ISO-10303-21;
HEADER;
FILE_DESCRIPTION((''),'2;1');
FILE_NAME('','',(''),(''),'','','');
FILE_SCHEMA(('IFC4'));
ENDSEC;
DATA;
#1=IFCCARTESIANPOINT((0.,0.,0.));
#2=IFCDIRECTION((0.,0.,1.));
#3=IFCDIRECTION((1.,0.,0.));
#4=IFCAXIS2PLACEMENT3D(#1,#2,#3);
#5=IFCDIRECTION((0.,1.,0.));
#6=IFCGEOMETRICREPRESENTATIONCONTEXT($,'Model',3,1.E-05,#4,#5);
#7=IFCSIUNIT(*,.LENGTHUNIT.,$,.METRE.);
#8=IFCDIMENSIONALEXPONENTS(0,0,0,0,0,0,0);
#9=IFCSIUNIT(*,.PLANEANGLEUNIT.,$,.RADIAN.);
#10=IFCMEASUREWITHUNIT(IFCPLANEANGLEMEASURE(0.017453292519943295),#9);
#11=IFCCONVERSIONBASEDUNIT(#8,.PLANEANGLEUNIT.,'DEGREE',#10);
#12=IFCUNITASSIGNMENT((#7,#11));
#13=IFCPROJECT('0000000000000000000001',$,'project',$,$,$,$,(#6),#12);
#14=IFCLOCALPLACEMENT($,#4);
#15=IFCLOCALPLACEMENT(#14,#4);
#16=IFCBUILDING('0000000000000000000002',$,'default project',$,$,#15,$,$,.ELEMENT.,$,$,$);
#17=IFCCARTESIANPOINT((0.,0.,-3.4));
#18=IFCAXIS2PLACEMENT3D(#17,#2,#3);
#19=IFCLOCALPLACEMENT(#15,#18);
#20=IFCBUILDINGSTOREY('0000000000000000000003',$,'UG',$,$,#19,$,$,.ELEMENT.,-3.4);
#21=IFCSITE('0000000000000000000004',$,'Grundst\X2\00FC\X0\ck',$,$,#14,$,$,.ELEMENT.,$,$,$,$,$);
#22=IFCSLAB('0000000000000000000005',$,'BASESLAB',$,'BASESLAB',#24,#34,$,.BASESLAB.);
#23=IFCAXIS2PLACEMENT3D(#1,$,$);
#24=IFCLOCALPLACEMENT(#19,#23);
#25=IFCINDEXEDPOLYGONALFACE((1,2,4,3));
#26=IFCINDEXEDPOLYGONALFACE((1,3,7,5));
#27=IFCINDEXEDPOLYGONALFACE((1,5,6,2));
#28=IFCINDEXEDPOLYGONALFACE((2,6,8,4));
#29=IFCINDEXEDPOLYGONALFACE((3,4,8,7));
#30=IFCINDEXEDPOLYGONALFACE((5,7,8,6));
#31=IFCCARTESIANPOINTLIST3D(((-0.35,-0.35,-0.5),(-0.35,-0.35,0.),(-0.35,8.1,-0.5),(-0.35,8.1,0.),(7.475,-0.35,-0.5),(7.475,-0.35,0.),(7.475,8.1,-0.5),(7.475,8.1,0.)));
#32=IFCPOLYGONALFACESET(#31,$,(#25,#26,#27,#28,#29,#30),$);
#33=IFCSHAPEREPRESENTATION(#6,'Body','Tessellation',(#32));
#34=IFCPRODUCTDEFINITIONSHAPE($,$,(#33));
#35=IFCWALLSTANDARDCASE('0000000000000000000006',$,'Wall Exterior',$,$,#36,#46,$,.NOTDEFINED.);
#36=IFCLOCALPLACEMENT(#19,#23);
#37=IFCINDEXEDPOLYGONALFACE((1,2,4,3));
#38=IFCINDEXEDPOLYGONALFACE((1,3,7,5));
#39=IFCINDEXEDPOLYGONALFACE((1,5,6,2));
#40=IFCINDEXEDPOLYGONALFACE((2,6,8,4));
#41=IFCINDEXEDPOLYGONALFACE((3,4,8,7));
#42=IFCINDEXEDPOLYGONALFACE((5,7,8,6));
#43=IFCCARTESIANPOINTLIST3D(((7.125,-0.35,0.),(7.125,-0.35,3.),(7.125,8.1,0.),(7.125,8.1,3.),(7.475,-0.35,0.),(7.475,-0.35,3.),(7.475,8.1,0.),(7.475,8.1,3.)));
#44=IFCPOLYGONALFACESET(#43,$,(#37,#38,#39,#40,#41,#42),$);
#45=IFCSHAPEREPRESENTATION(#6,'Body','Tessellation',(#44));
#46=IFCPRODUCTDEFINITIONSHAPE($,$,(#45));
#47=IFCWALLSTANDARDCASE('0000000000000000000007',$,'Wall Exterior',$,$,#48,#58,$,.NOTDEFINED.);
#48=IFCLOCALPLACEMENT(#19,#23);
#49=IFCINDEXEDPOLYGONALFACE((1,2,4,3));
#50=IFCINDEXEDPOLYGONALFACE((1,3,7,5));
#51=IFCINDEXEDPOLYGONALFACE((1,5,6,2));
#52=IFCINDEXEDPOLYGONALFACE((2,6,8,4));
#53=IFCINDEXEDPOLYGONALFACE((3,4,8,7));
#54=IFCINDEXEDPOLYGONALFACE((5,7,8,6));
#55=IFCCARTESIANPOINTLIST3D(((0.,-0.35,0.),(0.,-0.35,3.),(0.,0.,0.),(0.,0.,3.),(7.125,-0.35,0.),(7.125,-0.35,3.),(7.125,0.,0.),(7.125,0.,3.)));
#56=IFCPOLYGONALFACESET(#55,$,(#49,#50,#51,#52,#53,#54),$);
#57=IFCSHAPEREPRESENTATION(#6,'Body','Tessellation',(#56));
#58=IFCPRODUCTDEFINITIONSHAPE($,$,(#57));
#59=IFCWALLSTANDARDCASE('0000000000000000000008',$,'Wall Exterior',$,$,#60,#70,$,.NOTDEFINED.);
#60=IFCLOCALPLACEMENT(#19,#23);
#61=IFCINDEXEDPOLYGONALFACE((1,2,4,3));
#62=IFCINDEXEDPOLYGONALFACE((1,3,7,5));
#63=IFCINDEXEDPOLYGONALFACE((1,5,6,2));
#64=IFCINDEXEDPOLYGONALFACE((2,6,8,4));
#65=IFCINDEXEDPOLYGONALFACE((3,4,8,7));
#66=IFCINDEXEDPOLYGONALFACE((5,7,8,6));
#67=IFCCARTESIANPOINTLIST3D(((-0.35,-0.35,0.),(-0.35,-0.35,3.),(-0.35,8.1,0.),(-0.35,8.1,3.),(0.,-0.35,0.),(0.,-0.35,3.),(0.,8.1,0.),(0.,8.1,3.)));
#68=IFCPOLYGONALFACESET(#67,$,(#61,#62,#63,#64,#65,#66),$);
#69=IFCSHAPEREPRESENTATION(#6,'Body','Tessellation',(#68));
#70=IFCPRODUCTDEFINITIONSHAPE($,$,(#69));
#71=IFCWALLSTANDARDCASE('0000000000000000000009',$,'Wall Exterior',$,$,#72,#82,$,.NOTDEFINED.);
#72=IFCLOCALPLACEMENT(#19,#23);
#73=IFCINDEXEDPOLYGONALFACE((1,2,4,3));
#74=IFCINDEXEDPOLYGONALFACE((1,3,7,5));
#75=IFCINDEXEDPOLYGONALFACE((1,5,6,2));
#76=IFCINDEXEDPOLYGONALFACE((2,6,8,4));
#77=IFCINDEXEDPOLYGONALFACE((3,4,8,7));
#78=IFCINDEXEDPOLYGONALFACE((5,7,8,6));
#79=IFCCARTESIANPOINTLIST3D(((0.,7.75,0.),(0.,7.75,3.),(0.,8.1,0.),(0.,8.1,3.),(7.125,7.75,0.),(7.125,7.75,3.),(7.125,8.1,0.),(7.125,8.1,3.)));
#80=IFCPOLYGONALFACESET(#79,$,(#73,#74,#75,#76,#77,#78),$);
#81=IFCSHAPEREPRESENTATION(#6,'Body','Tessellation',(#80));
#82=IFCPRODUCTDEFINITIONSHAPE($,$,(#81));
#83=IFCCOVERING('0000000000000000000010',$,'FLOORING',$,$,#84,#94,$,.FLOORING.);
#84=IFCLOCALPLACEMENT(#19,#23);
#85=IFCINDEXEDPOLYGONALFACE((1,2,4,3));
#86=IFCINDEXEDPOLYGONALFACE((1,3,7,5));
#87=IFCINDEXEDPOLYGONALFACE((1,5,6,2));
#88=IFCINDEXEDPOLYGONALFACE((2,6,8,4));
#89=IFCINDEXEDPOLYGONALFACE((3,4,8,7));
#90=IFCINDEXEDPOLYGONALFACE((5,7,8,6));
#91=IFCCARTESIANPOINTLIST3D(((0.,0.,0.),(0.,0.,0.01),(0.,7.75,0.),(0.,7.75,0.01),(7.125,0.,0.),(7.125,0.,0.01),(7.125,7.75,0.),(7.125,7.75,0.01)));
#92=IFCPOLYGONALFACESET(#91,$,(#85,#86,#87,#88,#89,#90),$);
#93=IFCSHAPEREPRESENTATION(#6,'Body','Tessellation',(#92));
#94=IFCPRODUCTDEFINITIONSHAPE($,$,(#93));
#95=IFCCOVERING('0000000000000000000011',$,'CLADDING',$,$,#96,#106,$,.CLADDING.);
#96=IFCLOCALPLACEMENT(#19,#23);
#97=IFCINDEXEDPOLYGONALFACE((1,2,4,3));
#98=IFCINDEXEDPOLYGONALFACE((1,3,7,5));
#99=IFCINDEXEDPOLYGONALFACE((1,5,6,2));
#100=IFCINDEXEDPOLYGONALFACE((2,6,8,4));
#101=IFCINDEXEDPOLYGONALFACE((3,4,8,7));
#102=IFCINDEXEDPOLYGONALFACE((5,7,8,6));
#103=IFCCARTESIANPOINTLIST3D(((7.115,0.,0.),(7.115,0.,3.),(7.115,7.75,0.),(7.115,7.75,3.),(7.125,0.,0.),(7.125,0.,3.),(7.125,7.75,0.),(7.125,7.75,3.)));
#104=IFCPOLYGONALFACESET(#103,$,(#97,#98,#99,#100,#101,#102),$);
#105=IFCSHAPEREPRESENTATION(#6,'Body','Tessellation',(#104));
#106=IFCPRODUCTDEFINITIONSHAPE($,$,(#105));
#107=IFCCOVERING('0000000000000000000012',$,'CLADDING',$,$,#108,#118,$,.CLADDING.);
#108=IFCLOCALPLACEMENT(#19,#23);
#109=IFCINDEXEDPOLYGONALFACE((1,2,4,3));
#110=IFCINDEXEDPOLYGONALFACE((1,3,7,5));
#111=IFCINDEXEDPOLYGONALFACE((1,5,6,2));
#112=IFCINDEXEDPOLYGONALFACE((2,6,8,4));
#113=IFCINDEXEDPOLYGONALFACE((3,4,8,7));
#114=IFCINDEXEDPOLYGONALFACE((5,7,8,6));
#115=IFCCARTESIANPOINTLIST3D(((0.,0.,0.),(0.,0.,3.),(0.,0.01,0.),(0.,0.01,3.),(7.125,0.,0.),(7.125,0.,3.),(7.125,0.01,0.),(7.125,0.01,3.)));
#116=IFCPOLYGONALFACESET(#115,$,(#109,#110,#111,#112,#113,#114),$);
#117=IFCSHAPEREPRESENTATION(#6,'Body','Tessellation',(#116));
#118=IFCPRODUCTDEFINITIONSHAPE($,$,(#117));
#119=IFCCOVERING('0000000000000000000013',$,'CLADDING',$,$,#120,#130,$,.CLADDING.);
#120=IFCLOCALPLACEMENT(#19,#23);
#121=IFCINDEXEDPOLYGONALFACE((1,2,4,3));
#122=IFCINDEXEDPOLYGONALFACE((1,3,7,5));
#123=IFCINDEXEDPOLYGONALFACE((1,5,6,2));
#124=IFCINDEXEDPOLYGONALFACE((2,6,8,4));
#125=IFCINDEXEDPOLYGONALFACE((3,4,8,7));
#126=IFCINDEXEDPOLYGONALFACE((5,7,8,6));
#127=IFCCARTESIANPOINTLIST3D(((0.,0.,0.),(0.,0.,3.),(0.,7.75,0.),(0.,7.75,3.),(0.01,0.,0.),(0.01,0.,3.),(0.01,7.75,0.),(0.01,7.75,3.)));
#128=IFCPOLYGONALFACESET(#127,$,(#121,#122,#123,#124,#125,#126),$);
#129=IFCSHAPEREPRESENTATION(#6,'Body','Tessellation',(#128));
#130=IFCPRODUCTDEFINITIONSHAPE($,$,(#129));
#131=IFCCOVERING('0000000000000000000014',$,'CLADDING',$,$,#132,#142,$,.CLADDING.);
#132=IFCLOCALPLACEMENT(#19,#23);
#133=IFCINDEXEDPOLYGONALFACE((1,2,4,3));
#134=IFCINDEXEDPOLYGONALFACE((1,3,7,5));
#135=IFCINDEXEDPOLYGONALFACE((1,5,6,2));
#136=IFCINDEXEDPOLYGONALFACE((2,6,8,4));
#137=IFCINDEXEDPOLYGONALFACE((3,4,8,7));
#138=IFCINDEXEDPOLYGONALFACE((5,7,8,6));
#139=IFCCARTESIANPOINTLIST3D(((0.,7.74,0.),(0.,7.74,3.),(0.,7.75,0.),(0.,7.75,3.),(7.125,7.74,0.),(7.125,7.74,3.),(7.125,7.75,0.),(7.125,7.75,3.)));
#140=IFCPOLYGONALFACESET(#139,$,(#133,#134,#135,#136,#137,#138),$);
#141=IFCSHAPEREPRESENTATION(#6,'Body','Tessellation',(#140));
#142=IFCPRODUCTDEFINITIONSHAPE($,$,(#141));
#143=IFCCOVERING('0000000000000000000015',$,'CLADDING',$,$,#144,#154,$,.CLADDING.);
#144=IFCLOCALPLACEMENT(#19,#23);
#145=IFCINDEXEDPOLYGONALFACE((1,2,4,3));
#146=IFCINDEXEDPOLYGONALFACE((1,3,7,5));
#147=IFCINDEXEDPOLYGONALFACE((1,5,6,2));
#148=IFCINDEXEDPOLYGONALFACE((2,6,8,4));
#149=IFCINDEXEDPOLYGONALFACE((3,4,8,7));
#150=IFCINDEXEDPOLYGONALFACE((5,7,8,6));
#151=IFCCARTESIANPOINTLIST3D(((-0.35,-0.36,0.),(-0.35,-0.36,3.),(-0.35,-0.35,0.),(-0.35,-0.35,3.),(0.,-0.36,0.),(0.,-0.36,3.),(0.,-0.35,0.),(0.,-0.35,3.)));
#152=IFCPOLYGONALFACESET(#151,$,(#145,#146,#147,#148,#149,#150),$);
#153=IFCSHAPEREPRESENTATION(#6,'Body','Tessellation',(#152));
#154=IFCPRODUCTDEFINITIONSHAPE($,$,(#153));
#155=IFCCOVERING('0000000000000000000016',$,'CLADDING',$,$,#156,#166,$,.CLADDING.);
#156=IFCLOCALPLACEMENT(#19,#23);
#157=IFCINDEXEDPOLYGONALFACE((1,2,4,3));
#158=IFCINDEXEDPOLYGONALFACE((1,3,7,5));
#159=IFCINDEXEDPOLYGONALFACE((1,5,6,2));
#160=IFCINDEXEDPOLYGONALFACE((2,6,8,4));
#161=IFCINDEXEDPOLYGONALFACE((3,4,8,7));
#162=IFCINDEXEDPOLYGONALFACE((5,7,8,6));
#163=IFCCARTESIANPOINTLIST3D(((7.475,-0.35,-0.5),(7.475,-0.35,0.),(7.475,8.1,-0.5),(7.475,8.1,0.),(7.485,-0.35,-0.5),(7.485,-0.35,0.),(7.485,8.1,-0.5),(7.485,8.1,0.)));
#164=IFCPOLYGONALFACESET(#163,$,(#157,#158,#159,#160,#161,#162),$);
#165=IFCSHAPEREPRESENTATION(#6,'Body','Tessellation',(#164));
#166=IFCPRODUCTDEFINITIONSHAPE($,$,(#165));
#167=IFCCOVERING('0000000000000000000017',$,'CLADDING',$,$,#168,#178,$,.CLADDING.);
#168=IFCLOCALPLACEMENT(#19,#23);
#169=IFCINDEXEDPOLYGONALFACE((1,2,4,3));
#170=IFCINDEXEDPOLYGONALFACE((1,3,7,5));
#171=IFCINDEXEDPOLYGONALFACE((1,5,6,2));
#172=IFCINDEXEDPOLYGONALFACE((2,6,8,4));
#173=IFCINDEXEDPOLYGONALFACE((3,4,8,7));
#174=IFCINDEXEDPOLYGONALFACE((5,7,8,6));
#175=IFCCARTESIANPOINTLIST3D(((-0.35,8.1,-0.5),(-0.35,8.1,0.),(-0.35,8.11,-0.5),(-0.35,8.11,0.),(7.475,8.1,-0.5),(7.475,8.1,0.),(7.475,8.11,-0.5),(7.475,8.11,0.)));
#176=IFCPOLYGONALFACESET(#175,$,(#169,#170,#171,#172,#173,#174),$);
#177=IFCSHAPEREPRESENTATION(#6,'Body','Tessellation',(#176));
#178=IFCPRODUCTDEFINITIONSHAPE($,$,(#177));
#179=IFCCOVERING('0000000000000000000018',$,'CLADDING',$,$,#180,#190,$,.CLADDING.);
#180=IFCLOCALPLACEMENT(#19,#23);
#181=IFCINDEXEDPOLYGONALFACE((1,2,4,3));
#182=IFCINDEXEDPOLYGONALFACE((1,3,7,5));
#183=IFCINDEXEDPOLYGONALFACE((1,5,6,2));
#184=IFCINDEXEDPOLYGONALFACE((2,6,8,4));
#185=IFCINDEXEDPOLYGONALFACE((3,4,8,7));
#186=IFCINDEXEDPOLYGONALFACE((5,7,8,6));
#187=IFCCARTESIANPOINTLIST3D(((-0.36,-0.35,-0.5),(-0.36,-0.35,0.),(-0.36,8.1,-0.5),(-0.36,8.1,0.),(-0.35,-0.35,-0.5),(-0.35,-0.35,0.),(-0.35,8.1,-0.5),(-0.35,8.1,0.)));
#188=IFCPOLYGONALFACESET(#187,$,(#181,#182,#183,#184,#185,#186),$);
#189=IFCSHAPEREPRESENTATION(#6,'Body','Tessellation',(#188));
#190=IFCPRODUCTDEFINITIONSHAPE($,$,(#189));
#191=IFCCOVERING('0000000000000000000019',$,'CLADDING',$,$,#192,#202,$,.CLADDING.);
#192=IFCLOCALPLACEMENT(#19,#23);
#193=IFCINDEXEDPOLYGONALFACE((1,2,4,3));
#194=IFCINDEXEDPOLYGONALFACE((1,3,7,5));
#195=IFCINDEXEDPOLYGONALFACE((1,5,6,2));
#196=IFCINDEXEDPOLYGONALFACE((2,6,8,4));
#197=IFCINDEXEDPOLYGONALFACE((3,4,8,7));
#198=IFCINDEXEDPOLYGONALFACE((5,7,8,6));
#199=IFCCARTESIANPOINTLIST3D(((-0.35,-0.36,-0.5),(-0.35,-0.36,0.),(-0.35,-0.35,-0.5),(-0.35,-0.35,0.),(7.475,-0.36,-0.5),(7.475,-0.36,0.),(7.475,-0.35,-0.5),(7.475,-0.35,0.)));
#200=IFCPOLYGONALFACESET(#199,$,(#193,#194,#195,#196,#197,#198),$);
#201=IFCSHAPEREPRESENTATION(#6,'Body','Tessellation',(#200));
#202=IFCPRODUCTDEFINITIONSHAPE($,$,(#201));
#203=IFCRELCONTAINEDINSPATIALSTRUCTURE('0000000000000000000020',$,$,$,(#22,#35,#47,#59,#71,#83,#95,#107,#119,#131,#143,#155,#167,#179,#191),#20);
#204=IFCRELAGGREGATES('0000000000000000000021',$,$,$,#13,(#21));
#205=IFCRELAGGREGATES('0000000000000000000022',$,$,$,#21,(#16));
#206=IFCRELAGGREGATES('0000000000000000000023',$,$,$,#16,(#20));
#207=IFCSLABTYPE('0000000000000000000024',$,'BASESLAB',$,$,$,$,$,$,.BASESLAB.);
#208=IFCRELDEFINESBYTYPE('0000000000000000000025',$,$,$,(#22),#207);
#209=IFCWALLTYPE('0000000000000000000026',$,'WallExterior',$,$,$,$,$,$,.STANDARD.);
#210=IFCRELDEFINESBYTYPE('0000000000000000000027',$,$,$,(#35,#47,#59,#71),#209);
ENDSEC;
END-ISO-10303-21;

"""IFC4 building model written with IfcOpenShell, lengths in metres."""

from ifc_helpers import new_model, entity, si_unit, converted_unit, direction, frame, origin_with_axes, place, context, project, spatial, polyline, outline, extrude, type_object, element, save


model = new_model("IFC4")

# Units and contexts
model_context = context("Model", 3, precision=1e-05, world=origin_with_axes(), true_north=direction((0.0, 1.0, 0.0)))
ifc_project = project(units=[si_unit("LENGTHUNIT", "METRE"), converted_unit("PLANEANGLEUNIT", "DEGREE", entity("IfcPlaneAngleMeasure", 0.017453292519943295), si_unit("PLANEANGLEUNIT", "RADIAN"), dimensions=[0, 0, 0, 0, 0, 0, 0])], contexts=[model_context])

# Site, building, storey
site_placement = place(None, origin_with_axes())
site = spatial("IfcSite", under=ifc_project, at=site_placement, Name="Grundstück", CompositionType="ELEMENT")
building_placement = place(site_placement, origin_with_axes())
building = spatial("IfcBuilding", under=site, at=building_placement, Name="default project", CompositionType="ELEMENT")
placement_1 = place(building_placement, frame((0.0, 0.0, -3.4), z_axis=(0.0, 0.0, 1.0), x_axis=(1.0, 0.0, 0.0)))
storey = spatial("IfcBuildingStorey", under=building, at=placement_1, Name="UG", CompositionType="ELEMENT", Elevation=-3.4)

# Slab
slab_type = type_object("IfcSlabType", Name="BASESLAB", PredefinedType="BASESLAB")
slab_placement = place(placement_1, frame((0.0, 0.0, -0.5), z_axis=(0.0, 0.0, 1.0), x_axis=(1.0, 0.0, 0.0)))
element("IfcSlab", 1, at=slab_placement, inside=storey, type_object=slab_type, Name="BASESLAB", ObjectType="BASESLAB", PredefinedType="BASESLAB", context=model_context, shape_type="SweptSolid", body=[
    extrude(outline(polyline([(7.475, 8.1), (-0.35, 8.1), (-0.35, -0.35), (7.475, -0.35), (7.475, 8.1)])), origin_with_axes(), (0.0, 0.0, 1.0), 0.5),
])

# Walls
wall_type = type_object("IfcWallType", Name="WallExterior", PredefinedType="STANDARD")
placement_2 = place(placement_1, frame((7.3, 7.925, 0.0), z_axis=(0.0, 0.0, 1.0), x_axis=(0.0, -1.0, 0.0)))
element("IfcWallStandardCase", 2, at=placement_2, inside=storey, type_object=wall_type, Name="Wall Exterior", PredefinedType="NOTDEFINED", context=model_context, shape_type="SweptSolid", body=[
    extrude(outline(polyline([(-0.175, -0.175), (8.275, -0.175), (8.275, 0.175), (-0.175, 0.175), (-0.175, -0.175)])), origin_with_axes(), (0.0, 0.0, 1.0), 3.0),
])
placement_3 = place(placement_1, frame((7.3, -0.175, 0.0), z_axis=(0.0, 0.0, 1.0), x_axis=(-1.0, 0.0, 0.0)))
element("IfcWallStandardCase", 3, at=placement_3, inside=storey, type_object=wall_type, Name="Wall Exterior", PredefinedType="NOTDEFINED", context=model_context, shape_type="SweptSolid", body=[
    extrude(outline(polyline([(0.175, -0.175), (7.3, -0.175), (7.3, 0.175), (0.175, 0.175), (0.175, -0.175)])), origin_with_axes(), (0.0, 0.0, 1.0), 3.0),
])
placement_4 = place(placement_1, frame((-0.175, -0.175, 0.0), z_axis=(0.0, 0.0, 1.0), x_axis=(0.0, 1.0, 0.0)))
element("IfcWallStandardCase", 4, at=placement_4, inside=storey, type_object=wall_type, Name="Wall Exterior", PredefinedType="NOTDEFINED", context=model_context, shape_type="SweptSolid", body=[
    extrude(outline(polyline([(-0.175, -0.175), (8.275, -0.175), (8.275, 0.175), (-0.175, 0.175), (-0.175, -0.175)])), origin_with_axes(), (0.0, 0.0, 1.0), 3.0),
])
placement_5 = place(placement_1, frame((-0.175, 7.925, 0.0), z_axis=(0.0, 0.0, 1.0), x_axis=(1.0, 0.0, 0.0)))
element("IfcWallStandardCase", 5, at=placement_5, inside=storey, type_object=wall_type, Name="Wall Exterior", PredefinedType="NOTDEFINED", context=model_context, shape_type="SweptSolid", body=[
    extrude(outline(polyline([(7.3, 0.175), (0.175, 0.175), (0.175, -0.175), (7.3, -0.175), (7.3, 0.175)])), origin_with_axes(), (0.0, 0.0, 1.0), 3.0),
])

# Coverings
element("IfcCovering", 6, at=placement_1, inside=storey, Name="FLOORING", PredefinedType="FLOORING", context=model_context, shape_type="SweptSolid", body=[
    extrude(outline(polyline([(7.125, 7.75), (0.0, 7.75), (0.0, 0.0), (7.125, 0.0), (7.125, 7.75)])), origin_with_axes(), (0.0, 0.0, 1.0), 0.01),
])
element("IfcCovering", 7, at=placement_1, inside=storey, Name="CLADDING", PredefinedType="CLADDING", context=model_context, shape_type="SweptSolid", body=[
    extrude(outline(polyline([(7.115, 7.75), (7.115, 0.0), (7.125, 0.0), (7.125, 7.75), (7.115, 7.75)])), origin_with_axes(), (0.0, 0.0, 1.0), 3.0),
])
element("IfcCovering", 8, at=placement_1, inside=storey, Name="CLADDING", PredefinedType="CLADDING", context=model_context, shape_type="SweptSolid", body=[
    extrude(outline(polyline([(7.125, 0.01), (0.0, 0.01), (0.0, 0.0), (7.125, 0.0), (7.125, 0.01)])), origin_with_axes(), (0.0, 0.0, 1.0), 3.0),
])
element("IfcCovering", 9, at=placement_1, inside=storey, Name="CLADDING", PredefinedType="CLADDING", context=model_context, shape_type="SweptSolid", body=[
    extrude(outline(polyline([(0.01, 0.0), (0.01, 7.75), (0.0, 7.75), (0.0, 0.0), (0.01, 0.0)])), origin_with_axes(), (0.0, 0.0, 1.0), 3.0),
])
element("IfcCovering", 10, at=placement_1, inside=storey, Name="CLADDING", PredefinedType="CLADDING", context=model_context, shape_type="SweptSolid", body=[
    extrude(outline(polyline([(0.0, 7.74), (7.125, 7.74), (7.125, 7.75), (0.0, 7.75), (0.0, 7.74)])), origin_with_axes(), (0.0, 0.0, 1.0), 3.0),
])
element("IfcCovering", 11, at=placement_4, inside=storey, Name="CLADDING", PredefinedType="CLADDING", context=model_context, shape_type="SweptSolid", body=[
    extrude(outline(polyline([(-0.185, 0.175), (-0.185, -0.175), (-0.175, -0.175), (-0.175, 0.175), (-0.185, 0.175)])), origin_with_axes(), (0.0, 0.0, 1.0), 3.0),
])
covering_1_placement = place(slab_placement, origin_with_axes())
element("IfcCovering", 12, at=covering_1_placement, inside=storey, Name="CLADDING", PredefinedType="CLADDING", context=model_context, shape_type="SweptSolid", body=[
    extrude(outline(polyline([(7.485, -0.35), (7.485, 8.1), (7.475, 8.1), (7.475, -0.35), (7.485, -0.35)])), origin_with_axes(), (0.0, 0.0, 1.0), 0.5),
])
covering_2_placement = place(slab_placement, origin_with_axes())
element("IfcCovering", 13, at=covering_2_placement, inside=storey, Name="CLADDING", PredefinedType="CLADDING", context=model_context, shape_type="SweptSolid", body=[
    extrude(outline(polyline([(7.475, 8.11), (-0.35, 8.11), (-0.35, 8.1), (7.475, 8.1), (7.475, 8.11)])), origin_with_axes(), (0.0, 0.0, 1.0), 0.5),
])
covering_3_placement = place(slab_placement, origin_with_axes())
element("IfcCovering", 14, at=covering_3_placement, inside=storey, Name="CLADDING", PredefinedType="CLADDING", context=model_context, shape_type="SweptSolid", body=[
    extrude(outline(polyline([(-0.36, 8.1), (-0.36, -0.35), (-0.35, -0.35), (-0.35, 8.1), (-0.36, 8.1)])), origin_with_axes(), (0.0, 0.0, 1.0), 0.5),
])
covering_4_placement = place(slab_placement, origin_with_axes())
element("IfcCovering", 15, at=covering_4_placement, inside=storey, Name="CLADDING", PredefinedType="CLADDING", context=model_context, shape_type="SweptSolid", body=[
    extrude(outline(polyline([(-0.35, -0.36), (7.475, -0.36), (7.475, -0.35), (-0.35, -0.35), (-0.35, -0.36)])), origin_with_axes(), (0.0, 0.0, 1.0), 0.5),
])

save(model, "model.ifc")
